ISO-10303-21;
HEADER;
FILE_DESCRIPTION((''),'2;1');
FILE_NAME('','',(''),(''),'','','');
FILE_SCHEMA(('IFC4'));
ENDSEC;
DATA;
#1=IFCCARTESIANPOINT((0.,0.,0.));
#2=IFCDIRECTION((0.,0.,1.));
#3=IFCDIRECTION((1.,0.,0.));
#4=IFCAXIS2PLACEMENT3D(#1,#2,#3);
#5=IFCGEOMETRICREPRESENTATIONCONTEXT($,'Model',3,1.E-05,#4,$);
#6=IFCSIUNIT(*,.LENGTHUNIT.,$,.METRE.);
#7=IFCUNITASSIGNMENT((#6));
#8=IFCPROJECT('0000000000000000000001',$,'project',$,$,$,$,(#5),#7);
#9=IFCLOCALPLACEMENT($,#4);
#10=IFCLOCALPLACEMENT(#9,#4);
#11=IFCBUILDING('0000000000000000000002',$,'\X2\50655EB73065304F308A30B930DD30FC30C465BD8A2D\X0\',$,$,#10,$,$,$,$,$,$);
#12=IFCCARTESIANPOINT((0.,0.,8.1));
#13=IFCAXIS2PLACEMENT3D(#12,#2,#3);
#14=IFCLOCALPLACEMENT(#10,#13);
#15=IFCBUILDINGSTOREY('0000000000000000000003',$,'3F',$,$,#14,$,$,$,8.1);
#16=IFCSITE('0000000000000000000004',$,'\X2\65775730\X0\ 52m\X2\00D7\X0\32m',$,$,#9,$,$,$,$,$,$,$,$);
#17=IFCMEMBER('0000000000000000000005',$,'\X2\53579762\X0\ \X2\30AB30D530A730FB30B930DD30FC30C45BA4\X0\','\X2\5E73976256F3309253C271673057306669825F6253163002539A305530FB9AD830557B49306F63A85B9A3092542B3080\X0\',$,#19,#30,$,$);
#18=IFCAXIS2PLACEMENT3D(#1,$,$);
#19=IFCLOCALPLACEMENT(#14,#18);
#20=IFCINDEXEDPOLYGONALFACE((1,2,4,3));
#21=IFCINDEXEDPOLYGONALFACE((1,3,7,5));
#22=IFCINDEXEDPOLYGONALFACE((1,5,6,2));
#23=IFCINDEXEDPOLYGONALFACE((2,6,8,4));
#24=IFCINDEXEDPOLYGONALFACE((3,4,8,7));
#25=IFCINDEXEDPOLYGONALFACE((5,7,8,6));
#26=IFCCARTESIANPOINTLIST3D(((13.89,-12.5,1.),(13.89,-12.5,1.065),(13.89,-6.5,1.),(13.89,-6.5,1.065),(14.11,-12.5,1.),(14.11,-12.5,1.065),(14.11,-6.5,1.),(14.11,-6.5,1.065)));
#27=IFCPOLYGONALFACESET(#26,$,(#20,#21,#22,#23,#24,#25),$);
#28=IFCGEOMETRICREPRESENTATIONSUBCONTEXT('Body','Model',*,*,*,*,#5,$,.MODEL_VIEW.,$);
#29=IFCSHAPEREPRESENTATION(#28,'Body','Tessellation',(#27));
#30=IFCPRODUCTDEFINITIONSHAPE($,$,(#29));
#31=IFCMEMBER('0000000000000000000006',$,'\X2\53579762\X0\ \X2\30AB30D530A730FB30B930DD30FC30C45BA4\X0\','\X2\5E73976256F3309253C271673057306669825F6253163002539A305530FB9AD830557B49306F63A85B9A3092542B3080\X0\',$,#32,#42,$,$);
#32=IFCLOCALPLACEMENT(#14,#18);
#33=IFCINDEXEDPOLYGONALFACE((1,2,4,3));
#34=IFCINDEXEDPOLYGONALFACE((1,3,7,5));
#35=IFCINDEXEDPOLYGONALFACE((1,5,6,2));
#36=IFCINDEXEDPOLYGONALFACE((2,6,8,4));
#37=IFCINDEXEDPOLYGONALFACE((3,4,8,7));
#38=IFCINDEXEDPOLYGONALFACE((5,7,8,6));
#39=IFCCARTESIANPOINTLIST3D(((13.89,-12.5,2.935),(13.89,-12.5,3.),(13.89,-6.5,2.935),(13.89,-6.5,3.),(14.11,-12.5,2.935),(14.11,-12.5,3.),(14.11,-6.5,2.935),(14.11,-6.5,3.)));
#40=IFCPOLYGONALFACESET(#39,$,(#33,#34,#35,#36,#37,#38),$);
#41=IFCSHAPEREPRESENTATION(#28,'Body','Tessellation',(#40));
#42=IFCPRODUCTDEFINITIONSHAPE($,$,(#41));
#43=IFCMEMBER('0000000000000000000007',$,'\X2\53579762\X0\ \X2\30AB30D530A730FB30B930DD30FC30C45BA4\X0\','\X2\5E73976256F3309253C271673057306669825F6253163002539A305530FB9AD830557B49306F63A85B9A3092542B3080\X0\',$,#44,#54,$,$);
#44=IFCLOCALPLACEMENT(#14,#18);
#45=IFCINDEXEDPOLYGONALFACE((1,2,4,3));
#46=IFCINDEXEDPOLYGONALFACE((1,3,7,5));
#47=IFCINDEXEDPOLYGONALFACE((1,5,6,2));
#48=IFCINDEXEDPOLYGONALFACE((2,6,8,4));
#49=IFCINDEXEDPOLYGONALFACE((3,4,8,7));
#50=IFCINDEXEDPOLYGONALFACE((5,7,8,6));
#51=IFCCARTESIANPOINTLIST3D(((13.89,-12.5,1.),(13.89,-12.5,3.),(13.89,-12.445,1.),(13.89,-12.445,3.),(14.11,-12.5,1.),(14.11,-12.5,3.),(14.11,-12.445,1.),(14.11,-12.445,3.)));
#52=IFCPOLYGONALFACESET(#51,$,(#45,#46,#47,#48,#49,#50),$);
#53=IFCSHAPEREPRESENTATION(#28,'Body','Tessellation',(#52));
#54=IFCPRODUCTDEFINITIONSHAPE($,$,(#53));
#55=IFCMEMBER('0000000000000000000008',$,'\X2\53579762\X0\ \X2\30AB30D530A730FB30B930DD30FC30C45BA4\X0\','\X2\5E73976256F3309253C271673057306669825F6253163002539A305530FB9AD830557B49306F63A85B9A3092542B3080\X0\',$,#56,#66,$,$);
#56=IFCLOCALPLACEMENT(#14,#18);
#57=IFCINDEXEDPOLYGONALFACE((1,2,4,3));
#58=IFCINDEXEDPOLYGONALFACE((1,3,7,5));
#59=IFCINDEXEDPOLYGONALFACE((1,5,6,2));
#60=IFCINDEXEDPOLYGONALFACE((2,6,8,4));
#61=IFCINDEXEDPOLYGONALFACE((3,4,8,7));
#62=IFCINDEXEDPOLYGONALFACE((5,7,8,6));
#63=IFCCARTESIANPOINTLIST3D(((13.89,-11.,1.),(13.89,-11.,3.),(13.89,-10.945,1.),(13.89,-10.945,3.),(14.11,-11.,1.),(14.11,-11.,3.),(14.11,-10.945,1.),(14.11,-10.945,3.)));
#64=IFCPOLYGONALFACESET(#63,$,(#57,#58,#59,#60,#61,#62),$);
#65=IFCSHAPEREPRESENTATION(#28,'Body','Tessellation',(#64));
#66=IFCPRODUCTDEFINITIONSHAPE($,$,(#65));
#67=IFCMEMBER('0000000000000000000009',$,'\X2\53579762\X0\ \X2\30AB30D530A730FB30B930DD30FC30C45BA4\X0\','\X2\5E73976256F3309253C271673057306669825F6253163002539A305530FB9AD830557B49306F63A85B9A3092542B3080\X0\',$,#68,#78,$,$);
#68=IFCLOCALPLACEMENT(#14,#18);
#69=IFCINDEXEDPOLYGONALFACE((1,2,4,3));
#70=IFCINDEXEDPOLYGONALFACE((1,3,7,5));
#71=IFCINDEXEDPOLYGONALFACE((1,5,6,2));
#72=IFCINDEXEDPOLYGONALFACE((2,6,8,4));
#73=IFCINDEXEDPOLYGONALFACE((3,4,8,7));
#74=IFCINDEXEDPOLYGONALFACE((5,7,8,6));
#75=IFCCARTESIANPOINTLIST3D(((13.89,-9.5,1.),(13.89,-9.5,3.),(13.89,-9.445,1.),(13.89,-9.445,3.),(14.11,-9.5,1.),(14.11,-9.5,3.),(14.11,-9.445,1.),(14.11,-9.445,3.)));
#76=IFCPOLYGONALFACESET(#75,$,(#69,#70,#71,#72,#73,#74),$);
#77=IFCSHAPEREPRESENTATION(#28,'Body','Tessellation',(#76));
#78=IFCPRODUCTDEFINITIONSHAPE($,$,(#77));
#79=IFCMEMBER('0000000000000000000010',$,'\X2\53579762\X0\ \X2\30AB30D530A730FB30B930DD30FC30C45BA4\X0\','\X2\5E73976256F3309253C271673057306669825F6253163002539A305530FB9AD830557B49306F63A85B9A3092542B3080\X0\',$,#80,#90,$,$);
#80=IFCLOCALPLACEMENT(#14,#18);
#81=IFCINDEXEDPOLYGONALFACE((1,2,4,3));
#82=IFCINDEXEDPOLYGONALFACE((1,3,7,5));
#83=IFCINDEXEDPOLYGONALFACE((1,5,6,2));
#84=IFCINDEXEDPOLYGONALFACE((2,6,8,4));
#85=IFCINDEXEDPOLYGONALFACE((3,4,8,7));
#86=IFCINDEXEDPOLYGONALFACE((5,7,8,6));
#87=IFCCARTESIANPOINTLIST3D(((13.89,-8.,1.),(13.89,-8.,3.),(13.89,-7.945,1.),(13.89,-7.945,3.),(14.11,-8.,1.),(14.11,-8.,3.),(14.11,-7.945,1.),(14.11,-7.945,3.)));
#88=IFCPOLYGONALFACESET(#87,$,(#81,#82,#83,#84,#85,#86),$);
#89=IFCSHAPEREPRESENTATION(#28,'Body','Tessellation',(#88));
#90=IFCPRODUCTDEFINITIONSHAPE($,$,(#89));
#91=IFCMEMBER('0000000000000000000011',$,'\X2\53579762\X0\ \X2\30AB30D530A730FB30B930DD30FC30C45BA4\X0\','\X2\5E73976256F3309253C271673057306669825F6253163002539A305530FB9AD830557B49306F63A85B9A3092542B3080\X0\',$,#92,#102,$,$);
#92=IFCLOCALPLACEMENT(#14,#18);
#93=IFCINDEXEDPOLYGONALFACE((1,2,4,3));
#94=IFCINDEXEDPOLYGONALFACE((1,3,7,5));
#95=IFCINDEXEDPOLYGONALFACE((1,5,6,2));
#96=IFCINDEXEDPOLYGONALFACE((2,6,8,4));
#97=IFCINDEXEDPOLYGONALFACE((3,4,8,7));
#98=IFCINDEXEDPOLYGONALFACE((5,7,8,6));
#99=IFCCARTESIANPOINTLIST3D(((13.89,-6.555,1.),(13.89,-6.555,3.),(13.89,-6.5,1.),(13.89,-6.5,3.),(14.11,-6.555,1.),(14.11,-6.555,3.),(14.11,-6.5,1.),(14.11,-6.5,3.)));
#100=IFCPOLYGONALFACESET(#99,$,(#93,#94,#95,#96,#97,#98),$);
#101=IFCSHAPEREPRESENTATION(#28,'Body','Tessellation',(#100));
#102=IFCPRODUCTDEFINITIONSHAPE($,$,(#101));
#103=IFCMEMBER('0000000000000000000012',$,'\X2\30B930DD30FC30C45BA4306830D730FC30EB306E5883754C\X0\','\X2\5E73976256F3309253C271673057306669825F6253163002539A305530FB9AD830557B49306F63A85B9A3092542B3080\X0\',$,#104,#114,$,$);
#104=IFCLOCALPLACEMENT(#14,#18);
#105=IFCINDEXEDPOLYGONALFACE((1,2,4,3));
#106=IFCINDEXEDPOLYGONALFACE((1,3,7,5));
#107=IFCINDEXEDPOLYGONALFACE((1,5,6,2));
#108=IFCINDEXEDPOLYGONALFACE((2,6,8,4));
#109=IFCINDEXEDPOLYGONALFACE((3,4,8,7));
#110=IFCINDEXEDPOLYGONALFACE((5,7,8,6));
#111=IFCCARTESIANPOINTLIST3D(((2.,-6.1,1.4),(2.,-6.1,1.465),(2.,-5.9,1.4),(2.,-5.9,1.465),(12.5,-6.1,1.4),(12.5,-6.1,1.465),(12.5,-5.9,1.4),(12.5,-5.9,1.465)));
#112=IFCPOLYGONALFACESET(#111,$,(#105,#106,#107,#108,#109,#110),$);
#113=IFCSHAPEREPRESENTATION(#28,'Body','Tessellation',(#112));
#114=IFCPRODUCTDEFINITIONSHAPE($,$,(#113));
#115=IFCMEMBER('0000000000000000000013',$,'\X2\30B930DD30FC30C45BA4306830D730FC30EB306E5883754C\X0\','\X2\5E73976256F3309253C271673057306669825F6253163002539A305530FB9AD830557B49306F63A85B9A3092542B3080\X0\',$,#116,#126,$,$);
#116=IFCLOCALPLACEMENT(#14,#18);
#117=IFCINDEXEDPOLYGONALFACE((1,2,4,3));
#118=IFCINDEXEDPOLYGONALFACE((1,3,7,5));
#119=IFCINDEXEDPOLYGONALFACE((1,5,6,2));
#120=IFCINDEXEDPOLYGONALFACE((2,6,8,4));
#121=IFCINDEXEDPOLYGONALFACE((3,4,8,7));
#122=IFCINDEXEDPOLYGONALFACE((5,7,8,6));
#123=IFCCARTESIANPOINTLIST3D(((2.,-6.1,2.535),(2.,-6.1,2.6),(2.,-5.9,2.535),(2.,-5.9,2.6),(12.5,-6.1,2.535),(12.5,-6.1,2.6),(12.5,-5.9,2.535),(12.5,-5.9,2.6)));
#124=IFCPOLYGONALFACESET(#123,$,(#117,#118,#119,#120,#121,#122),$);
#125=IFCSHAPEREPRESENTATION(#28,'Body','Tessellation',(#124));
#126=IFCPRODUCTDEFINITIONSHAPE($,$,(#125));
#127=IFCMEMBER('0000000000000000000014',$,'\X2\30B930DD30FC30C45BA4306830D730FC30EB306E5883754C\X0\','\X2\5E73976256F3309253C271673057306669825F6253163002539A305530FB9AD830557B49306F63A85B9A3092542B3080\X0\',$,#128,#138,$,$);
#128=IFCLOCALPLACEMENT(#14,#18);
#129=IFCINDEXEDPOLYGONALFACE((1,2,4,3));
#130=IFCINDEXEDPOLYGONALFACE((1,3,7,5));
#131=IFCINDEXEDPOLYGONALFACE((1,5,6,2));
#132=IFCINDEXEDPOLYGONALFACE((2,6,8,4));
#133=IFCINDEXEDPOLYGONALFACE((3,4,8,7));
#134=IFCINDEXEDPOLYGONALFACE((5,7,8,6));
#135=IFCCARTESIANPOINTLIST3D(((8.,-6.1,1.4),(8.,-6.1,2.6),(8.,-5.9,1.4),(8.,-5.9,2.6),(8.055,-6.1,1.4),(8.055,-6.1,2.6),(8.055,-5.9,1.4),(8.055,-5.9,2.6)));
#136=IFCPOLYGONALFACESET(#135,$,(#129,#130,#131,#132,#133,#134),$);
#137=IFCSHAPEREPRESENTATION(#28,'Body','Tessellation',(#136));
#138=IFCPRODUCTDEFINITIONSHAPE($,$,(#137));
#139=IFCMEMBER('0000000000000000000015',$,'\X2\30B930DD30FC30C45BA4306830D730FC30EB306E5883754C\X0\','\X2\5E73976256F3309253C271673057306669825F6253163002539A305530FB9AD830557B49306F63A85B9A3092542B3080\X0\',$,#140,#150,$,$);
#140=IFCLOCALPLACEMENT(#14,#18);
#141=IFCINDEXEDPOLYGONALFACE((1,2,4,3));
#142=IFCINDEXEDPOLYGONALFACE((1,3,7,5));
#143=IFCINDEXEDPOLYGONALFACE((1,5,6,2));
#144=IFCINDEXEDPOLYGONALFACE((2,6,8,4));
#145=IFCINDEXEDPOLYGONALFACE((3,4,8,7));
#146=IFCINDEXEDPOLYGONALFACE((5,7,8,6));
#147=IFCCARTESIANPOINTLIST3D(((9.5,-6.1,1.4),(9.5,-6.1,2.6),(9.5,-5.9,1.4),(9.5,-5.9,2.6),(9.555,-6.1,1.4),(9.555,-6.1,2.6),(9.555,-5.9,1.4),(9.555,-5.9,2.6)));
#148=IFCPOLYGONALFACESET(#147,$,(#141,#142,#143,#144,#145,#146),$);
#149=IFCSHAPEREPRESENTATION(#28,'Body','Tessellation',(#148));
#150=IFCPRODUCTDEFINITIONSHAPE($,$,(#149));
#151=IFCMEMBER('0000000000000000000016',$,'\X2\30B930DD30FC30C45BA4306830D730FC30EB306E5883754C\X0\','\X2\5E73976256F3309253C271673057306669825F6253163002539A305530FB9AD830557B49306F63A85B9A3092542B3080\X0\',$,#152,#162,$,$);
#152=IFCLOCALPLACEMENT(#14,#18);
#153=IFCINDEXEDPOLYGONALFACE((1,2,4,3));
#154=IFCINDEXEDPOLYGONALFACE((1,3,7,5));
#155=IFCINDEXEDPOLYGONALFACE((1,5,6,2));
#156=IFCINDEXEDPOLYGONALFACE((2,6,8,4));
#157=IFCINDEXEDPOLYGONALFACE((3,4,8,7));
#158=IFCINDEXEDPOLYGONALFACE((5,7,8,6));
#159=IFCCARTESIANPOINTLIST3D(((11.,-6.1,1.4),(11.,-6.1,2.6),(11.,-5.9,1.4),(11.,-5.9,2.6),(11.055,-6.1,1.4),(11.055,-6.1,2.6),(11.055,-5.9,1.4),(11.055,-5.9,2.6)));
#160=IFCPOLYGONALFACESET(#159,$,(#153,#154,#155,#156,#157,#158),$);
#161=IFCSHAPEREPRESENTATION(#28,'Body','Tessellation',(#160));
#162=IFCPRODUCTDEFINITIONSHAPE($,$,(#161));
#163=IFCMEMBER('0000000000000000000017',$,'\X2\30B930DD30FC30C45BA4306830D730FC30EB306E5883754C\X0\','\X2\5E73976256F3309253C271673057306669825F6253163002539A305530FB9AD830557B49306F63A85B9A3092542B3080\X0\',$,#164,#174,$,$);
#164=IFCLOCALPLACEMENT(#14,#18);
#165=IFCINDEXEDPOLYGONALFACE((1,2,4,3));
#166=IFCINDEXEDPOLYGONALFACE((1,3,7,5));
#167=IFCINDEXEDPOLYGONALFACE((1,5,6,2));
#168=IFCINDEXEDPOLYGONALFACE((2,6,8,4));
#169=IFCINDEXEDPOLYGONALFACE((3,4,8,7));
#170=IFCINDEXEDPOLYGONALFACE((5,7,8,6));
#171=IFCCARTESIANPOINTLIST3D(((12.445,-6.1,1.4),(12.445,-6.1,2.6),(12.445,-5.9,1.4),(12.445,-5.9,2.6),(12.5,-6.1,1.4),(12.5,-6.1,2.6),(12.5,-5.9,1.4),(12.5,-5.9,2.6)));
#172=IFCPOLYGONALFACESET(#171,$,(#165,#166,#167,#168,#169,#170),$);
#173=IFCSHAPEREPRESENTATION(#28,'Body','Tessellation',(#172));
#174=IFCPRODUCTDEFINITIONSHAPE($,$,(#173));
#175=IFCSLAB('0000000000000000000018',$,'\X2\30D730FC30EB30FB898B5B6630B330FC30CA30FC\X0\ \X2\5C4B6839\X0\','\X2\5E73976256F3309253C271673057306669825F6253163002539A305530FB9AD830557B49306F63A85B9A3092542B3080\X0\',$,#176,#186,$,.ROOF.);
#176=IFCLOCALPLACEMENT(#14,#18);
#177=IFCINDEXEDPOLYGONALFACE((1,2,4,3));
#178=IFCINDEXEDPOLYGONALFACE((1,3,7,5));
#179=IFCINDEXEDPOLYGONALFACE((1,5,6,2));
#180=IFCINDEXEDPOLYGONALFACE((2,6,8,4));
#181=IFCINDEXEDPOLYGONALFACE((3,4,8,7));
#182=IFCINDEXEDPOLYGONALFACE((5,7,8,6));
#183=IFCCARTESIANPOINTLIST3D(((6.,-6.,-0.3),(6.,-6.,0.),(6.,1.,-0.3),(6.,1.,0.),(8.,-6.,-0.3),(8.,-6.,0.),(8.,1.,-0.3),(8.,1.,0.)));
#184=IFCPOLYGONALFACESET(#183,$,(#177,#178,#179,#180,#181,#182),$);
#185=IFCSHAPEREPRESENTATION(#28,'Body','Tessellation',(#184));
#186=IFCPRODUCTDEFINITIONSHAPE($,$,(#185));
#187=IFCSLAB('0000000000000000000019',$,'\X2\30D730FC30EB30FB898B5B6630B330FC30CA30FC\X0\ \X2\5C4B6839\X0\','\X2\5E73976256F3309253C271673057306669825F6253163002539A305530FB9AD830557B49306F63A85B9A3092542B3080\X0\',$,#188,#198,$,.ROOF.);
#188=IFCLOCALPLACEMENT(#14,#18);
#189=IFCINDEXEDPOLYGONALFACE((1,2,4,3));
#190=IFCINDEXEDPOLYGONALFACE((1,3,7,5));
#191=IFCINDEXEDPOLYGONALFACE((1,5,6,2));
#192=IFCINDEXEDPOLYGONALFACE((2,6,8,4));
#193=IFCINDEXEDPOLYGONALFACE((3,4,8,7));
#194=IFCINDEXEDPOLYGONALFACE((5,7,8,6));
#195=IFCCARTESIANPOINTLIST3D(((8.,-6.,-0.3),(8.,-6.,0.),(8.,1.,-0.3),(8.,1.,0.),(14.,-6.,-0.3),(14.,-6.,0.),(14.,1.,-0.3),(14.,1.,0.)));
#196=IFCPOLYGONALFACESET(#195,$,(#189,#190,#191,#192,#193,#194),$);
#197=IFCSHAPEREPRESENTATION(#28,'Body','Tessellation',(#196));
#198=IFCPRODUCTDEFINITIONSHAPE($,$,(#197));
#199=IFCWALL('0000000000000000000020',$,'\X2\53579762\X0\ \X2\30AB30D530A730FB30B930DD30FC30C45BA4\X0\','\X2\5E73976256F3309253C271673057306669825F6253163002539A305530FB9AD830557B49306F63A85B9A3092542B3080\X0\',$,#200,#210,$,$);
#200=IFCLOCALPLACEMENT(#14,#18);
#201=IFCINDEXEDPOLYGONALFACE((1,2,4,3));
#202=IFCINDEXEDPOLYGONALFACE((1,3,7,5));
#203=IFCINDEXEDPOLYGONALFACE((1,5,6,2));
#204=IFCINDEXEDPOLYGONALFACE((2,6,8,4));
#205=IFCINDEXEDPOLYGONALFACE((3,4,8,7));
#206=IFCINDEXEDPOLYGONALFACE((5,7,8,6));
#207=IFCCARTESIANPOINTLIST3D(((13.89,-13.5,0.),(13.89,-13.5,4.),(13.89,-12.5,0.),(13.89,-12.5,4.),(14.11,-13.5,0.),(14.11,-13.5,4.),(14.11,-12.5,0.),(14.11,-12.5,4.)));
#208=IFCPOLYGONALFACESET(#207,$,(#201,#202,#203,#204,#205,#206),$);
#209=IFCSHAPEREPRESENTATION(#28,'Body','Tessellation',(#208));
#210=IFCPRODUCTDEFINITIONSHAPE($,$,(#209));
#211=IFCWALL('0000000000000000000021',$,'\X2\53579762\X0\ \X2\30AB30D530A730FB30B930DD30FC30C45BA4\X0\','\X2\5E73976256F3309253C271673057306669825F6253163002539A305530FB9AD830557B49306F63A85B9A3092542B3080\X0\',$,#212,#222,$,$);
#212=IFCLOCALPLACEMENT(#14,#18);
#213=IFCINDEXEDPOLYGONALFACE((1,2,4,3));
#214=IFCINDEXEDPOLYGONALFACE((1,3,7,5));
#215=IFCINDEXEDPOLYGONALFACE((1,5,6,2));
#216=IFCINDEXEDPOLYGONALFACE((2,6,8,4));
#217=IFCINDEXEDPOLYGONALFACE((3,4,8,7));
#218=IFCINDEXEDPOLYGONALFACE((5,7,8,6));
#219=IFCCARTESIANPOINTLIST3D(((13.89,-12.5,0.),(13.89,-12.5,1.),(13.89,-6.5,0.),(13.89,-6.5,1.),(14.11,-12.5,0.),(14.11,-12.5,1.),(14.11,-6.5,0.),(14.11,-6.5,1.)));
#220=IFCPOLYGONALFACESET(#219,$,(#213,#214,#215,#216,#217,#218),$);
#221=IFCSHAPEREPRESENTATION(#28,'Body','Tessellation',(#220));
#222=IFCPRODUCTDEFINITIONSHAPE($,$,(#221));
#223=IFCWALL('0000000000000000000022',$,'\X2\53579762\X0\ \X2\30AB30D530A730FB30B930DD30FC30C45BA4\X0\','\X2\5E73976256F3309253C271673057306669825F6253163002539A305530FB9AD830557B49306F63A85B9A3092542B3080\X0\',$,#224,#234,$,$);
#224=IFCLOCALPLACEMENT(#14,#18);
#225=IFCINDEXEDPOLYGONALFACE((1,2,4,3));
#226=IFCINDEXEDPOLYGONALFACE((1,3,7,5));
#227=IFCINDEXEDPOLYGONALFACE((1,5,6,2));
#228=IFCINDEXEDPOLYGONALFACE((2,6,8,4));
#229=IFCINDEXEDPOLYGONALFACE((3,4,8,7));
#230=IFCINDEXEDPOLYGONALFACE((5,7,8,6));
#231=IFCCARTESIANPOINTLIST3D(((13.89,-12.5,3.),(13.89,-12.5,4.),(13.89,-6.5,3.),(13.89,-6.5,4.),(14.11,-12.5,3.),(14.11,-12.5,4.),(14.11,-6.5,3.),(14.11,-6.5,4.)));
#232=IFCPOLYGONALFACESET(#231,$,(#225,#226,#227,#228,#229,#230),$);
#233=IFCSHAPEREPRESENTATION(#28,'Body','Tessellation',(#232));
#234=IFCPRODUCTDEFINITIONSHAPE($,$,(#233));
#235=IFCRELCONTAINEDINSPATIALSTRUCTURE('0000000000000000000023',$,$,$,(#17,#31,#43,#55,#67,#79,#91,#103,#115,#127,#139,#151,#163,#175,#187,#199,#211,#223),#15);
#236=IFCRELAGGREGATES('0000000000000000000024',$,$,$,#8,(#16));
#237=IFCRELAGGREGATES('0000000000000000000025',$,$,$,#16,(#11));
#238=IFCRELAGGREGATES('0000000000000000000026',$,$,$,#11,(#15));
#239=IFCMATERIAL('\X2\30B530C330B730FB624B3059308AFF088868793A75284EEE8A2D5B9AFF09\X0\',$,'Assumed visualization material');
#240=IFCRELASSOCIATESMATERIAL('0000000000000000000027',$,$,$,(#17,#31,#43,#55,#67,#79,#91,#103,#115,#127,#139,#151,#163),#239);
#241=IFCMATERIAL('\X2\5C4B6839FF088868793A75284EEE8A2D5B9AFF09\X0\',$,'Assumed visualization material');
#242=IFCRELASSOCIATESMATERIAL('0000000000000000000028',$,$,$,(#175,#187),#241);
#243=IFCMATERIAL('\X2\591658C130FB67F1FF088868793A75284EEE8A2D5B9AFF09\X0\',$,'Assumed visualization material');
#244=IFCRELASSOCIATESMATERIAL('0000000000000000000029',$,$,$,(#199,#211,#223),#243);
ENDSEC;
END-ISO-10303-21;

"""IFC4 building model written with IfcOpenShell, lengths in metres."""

from ifc_helpers import new_model, si_unit, frame, origin_with_axes, place, context, subcontext, project, spatial, rectangle, extrude, material, element, save


model = new_model("IFC4")

# Units and contexts
model_context = context("Model", 3, precision=1e-05, world=origin_with_axes())
body_context = subcontext(model_context, "Body", "Model", "MODEL_VIEW")
ifc_project = project(units=[si_unit("LENGTHUNIT", "METRE")], contexts=[model_context])

# Site, building, storey
site_placement = place(None, origin_with_axes())
site = spatial("IfcSite", under=ifc_project, at=site_placement, Name="敷地 52m×32m")
building_placement = place(site_placement, origin_with_axes())
building = spatial("IfcBuilding", under=site, at=building_placement, Name="健康づくりスポーツ施設")
storey_placement = place(building_placement, frame((0.0, 0.0, 8.1), z_axis=(0.0, 0.0, 1.0), x_axis=(1.0, 0.0, 0.0)))
storey = spatial("IfcBuildingStorey", under=building, at=storey_placement, Name="3F", Elevation=8.1)

# Members
ifc_material_1 = material(Name="サッシ・手すり（表示用仮設定）", Category="Assumed visualization material")
for number, where, z_axis, x_axis, name in (
    (1, (14.0, -9.5, 1.0), (0.0, 0.0, 1.0), (1.0, 0.0, 0.0), "南面 カフェ・スポーツ室"),
    (2, (14.0, -9.5, 2.935), (0.0, 0.0, 1.0), (1.0, 0.0, 0.0), "南面 カフェ・スポーツ室"),
):
    element("IfcMember", number, at=place(storey_placement, frame(where, z_axis=z_axis, x_axis=x_axis)), inside=storey, material=ifc_material_1, Name=name, Description="平面図を参照して概形化。厚さ・高さ等は推定を含む", context=body_context, shape_type="SweptSolid", body=[
        extrude(rectangle(XDim=0.22, YDim=6.0), origin_with_axes(), (0.0, 0.0, 1.0), 0.065),
    ])
for number, where, z_axis, x_axis, name in (
    (3, (14.0, -12.4725, 1.0), (0.0, 0.0, 1.0), (1.0, 0.0, 0.0), "南面 カフェ・スポーツ室"),
    (4, (14.0, -10.9725, 1.0), (0.0, 0.0, 1.0), (1.0, 0.0, 0.0), "南面 カフェ・スポーツ室"),
    (5, (14.0, -9.4725, 1.0), (0.0, 0.0, 1.0), (1.0, 0.0, 0.0), "南面 カフェ・スポーツ室"),
    (6, (14.0, -7.9725, 1.0), (0.0, 0.0, 1.0), (1.0, 0.0, 0.0), "南面 カフェ・スポーツ室"),
    (7, (14.0, -6.5275, 1.0), (0.0, 0.0, 1.0), (1.0, 0.0, 0.0), "南面 カフェ・スポーツ室"),
):
    element("IfcMember", number, at=place(storey_placement, frame(where, z_axis=z_axis, x_axis=x_axis)), inside=storey, material=ifc_material_1, Name=name, Description="平面図を参照して概形化。厚さ・高さ等は推定を含む", context=body_context, shape_type="SweptSolid", body=[
        extrude(rectangle(XDim=0.22, YDim=0.055), origin_with_axes(), (0.0, 0.0, 1.0), 2.0),
    ])
for number, where, z_axis, x_axis, name in (
    (8, (7.25, -6.0, 1.4), (0.0, 0.0, 1.0), (1.0, 0.0, 0.0), "スポーツ室とプールの境界"),
    (9, (7.25, -6.0, 2.535), (0.0, 0.0, 1.0), (1.0, 0.0, 0.0), "スポーツ室とプールの境界"),
):
    element("IfcMember", number, at=place(storey_placement, frame(where, z_axis=z_axis, x_axis=x_axis)), inside=storey, material=ifc_material_1, Name=name, Description="平面図を参照して概形化。厚さ・高さ等は推定を含む", context=body_context, shape_type="SweptSolid", body=[
        extrude(rectangle(XDim=10.5, YDim=0.2), origin_with_axes(), (0.0, 0.0, 1.0), 0.065),
    ])
for number, where, z_axis, x_axis, name in (
    (10, (8.0275, -6.0, 1.4), (0.0, 0.0, 1.0), (1.0, 0.0, 0.0), "スポーツ室とプールの境界"),
    (11, (9.5275, -6.0, 1.4), (0.0, 0.0, 1.0), (1.0, 0.0, 0.0), "スポーツ室とプールの境界"),
    (12, (11.0275, -6.0, 1.4), (0.0, 0.0, 1.0), (1.0, 0.0, 0.0), "スポーツ室とプールの境界"),
    (13, (12.4725, -6.0, 1.4), (0.0, 0.0, 1.0), (1.0, 0.0, 0.0), "スポーツ室とプールの境界"),
):
    element("IfcMember", number, at=place(storey_placement, frame(where, z_axis=z_axis, x_axis=x_axis)), inside=storey, material=ifc_material_1, Name=name, Description="平面図を参照して概形化。厚さ・高さ等は推定を含む", context=body_context, shape_type="SweptSolid", body=[
        extrude(rectangle(XDim=0.055, YDim=0.2), origin_with_axes(), (0.0, 0.0, 1.0), 1.2),
    ])

# Slabs
ifc_material_2 = material(Name="屋根（表示用仮設定）", Category="Assumed visualization material")
slab_1_placement = place(storey_placement, frame((7.0, -2.5, -0.3), z_axis=(0.0, 0.0, 1.0), x_axis=(1.0, 0.0, 0.0)))
element("IfcSlab", 14, at=slab_1_placement, inside=storey, material=ifc_material_2, Name="プール・見学コーナー 屋根", Description="平面図を参照して概形化。厚さ・高さ等は推定を含む", PredefinedType="ROOF", context=body_context, shape_type="SweptSolid", body=[
    extrude(rectangle(XDim=2.0, YDim=7.0), origin_with_axes(), (0.0, 0.0, 1.0), 0.3),
])
slab_2_placement = place(storey_placement, frame((11.0, -2.5, -0.3), z_axis=(0.0, 0.0, 1.0), x_axis=(1.0, 0.0, 0.0)))
element("IfcSlab", 15, at=slab_2_placement, inside=storey, material=ifc_material_2, Name="プール・見学コーナー 屋根", Description="平面図を参照して概形化。厚さ・高さ等は推定を含む", PredefinedType="ROOF", context=body_context, shape_type="SweptSolid", body=[
    extrude(rectangle(XDim=6.0, YDim=7.0), origin_with_axes(), (0.0, 0.0, 1.0), 0.3),
])

# Walls
ifc_material_3 = material(Name="外壁・柱（表示用仮設定）", Category="Assumed visualization material")
wall_1_placement = place(storey_placement, frame((14.0, -13.0, 0.0), z_axis=(0.0, 0.0, 1.0), x_axis=(1.0, 0.0, 0.0)))
element("IfcWall", 16, at=wall_1_placement, inside=storey, material=ifc_material_3, Name="南面 カフェ・スポーツ室", Description="平面図を参照して概形化。厚さ・高さ等は推定を含む", context=body_context, shape_type="SweptSolid", body=[
    extrude(rectangle(XDim=0.22, YDim=1.0), origin_with_axes(), (0.0, 0.0, 1.0), 4.0),
])
for number, where, z_axis, x_axis, name in (
    (17, (14.0, -9.5, 0.0), (0.0, 0.0, 1.0), (1.0, 0.0, 0.0), "南面 カフェ・スポーツ室"),
    (18, (14.0, -9.5, 3.0), (0.0, 0.0, 1.0), (1.0, 0.0, 0.0), "南面 カフェ・スポーツ室"),
):
    element("IfcWall", number, at=place(storey_placement, frame(where, z_axis=z_axis, x_axis=x_axis)), inside=storey, material=ifc_material_3, Name=name, Description="平面図を参照して概形化。厚さ・高さ等は推定を含む", context=body_context, shape_type="SweptSolid", body=[
        extrude(rectangle(XDim=0.22, YDim=6.0), origin_with_axes(), (0.0, 0.0, 1.0), 1.0),
    ])

save(model, "model.ifc")
